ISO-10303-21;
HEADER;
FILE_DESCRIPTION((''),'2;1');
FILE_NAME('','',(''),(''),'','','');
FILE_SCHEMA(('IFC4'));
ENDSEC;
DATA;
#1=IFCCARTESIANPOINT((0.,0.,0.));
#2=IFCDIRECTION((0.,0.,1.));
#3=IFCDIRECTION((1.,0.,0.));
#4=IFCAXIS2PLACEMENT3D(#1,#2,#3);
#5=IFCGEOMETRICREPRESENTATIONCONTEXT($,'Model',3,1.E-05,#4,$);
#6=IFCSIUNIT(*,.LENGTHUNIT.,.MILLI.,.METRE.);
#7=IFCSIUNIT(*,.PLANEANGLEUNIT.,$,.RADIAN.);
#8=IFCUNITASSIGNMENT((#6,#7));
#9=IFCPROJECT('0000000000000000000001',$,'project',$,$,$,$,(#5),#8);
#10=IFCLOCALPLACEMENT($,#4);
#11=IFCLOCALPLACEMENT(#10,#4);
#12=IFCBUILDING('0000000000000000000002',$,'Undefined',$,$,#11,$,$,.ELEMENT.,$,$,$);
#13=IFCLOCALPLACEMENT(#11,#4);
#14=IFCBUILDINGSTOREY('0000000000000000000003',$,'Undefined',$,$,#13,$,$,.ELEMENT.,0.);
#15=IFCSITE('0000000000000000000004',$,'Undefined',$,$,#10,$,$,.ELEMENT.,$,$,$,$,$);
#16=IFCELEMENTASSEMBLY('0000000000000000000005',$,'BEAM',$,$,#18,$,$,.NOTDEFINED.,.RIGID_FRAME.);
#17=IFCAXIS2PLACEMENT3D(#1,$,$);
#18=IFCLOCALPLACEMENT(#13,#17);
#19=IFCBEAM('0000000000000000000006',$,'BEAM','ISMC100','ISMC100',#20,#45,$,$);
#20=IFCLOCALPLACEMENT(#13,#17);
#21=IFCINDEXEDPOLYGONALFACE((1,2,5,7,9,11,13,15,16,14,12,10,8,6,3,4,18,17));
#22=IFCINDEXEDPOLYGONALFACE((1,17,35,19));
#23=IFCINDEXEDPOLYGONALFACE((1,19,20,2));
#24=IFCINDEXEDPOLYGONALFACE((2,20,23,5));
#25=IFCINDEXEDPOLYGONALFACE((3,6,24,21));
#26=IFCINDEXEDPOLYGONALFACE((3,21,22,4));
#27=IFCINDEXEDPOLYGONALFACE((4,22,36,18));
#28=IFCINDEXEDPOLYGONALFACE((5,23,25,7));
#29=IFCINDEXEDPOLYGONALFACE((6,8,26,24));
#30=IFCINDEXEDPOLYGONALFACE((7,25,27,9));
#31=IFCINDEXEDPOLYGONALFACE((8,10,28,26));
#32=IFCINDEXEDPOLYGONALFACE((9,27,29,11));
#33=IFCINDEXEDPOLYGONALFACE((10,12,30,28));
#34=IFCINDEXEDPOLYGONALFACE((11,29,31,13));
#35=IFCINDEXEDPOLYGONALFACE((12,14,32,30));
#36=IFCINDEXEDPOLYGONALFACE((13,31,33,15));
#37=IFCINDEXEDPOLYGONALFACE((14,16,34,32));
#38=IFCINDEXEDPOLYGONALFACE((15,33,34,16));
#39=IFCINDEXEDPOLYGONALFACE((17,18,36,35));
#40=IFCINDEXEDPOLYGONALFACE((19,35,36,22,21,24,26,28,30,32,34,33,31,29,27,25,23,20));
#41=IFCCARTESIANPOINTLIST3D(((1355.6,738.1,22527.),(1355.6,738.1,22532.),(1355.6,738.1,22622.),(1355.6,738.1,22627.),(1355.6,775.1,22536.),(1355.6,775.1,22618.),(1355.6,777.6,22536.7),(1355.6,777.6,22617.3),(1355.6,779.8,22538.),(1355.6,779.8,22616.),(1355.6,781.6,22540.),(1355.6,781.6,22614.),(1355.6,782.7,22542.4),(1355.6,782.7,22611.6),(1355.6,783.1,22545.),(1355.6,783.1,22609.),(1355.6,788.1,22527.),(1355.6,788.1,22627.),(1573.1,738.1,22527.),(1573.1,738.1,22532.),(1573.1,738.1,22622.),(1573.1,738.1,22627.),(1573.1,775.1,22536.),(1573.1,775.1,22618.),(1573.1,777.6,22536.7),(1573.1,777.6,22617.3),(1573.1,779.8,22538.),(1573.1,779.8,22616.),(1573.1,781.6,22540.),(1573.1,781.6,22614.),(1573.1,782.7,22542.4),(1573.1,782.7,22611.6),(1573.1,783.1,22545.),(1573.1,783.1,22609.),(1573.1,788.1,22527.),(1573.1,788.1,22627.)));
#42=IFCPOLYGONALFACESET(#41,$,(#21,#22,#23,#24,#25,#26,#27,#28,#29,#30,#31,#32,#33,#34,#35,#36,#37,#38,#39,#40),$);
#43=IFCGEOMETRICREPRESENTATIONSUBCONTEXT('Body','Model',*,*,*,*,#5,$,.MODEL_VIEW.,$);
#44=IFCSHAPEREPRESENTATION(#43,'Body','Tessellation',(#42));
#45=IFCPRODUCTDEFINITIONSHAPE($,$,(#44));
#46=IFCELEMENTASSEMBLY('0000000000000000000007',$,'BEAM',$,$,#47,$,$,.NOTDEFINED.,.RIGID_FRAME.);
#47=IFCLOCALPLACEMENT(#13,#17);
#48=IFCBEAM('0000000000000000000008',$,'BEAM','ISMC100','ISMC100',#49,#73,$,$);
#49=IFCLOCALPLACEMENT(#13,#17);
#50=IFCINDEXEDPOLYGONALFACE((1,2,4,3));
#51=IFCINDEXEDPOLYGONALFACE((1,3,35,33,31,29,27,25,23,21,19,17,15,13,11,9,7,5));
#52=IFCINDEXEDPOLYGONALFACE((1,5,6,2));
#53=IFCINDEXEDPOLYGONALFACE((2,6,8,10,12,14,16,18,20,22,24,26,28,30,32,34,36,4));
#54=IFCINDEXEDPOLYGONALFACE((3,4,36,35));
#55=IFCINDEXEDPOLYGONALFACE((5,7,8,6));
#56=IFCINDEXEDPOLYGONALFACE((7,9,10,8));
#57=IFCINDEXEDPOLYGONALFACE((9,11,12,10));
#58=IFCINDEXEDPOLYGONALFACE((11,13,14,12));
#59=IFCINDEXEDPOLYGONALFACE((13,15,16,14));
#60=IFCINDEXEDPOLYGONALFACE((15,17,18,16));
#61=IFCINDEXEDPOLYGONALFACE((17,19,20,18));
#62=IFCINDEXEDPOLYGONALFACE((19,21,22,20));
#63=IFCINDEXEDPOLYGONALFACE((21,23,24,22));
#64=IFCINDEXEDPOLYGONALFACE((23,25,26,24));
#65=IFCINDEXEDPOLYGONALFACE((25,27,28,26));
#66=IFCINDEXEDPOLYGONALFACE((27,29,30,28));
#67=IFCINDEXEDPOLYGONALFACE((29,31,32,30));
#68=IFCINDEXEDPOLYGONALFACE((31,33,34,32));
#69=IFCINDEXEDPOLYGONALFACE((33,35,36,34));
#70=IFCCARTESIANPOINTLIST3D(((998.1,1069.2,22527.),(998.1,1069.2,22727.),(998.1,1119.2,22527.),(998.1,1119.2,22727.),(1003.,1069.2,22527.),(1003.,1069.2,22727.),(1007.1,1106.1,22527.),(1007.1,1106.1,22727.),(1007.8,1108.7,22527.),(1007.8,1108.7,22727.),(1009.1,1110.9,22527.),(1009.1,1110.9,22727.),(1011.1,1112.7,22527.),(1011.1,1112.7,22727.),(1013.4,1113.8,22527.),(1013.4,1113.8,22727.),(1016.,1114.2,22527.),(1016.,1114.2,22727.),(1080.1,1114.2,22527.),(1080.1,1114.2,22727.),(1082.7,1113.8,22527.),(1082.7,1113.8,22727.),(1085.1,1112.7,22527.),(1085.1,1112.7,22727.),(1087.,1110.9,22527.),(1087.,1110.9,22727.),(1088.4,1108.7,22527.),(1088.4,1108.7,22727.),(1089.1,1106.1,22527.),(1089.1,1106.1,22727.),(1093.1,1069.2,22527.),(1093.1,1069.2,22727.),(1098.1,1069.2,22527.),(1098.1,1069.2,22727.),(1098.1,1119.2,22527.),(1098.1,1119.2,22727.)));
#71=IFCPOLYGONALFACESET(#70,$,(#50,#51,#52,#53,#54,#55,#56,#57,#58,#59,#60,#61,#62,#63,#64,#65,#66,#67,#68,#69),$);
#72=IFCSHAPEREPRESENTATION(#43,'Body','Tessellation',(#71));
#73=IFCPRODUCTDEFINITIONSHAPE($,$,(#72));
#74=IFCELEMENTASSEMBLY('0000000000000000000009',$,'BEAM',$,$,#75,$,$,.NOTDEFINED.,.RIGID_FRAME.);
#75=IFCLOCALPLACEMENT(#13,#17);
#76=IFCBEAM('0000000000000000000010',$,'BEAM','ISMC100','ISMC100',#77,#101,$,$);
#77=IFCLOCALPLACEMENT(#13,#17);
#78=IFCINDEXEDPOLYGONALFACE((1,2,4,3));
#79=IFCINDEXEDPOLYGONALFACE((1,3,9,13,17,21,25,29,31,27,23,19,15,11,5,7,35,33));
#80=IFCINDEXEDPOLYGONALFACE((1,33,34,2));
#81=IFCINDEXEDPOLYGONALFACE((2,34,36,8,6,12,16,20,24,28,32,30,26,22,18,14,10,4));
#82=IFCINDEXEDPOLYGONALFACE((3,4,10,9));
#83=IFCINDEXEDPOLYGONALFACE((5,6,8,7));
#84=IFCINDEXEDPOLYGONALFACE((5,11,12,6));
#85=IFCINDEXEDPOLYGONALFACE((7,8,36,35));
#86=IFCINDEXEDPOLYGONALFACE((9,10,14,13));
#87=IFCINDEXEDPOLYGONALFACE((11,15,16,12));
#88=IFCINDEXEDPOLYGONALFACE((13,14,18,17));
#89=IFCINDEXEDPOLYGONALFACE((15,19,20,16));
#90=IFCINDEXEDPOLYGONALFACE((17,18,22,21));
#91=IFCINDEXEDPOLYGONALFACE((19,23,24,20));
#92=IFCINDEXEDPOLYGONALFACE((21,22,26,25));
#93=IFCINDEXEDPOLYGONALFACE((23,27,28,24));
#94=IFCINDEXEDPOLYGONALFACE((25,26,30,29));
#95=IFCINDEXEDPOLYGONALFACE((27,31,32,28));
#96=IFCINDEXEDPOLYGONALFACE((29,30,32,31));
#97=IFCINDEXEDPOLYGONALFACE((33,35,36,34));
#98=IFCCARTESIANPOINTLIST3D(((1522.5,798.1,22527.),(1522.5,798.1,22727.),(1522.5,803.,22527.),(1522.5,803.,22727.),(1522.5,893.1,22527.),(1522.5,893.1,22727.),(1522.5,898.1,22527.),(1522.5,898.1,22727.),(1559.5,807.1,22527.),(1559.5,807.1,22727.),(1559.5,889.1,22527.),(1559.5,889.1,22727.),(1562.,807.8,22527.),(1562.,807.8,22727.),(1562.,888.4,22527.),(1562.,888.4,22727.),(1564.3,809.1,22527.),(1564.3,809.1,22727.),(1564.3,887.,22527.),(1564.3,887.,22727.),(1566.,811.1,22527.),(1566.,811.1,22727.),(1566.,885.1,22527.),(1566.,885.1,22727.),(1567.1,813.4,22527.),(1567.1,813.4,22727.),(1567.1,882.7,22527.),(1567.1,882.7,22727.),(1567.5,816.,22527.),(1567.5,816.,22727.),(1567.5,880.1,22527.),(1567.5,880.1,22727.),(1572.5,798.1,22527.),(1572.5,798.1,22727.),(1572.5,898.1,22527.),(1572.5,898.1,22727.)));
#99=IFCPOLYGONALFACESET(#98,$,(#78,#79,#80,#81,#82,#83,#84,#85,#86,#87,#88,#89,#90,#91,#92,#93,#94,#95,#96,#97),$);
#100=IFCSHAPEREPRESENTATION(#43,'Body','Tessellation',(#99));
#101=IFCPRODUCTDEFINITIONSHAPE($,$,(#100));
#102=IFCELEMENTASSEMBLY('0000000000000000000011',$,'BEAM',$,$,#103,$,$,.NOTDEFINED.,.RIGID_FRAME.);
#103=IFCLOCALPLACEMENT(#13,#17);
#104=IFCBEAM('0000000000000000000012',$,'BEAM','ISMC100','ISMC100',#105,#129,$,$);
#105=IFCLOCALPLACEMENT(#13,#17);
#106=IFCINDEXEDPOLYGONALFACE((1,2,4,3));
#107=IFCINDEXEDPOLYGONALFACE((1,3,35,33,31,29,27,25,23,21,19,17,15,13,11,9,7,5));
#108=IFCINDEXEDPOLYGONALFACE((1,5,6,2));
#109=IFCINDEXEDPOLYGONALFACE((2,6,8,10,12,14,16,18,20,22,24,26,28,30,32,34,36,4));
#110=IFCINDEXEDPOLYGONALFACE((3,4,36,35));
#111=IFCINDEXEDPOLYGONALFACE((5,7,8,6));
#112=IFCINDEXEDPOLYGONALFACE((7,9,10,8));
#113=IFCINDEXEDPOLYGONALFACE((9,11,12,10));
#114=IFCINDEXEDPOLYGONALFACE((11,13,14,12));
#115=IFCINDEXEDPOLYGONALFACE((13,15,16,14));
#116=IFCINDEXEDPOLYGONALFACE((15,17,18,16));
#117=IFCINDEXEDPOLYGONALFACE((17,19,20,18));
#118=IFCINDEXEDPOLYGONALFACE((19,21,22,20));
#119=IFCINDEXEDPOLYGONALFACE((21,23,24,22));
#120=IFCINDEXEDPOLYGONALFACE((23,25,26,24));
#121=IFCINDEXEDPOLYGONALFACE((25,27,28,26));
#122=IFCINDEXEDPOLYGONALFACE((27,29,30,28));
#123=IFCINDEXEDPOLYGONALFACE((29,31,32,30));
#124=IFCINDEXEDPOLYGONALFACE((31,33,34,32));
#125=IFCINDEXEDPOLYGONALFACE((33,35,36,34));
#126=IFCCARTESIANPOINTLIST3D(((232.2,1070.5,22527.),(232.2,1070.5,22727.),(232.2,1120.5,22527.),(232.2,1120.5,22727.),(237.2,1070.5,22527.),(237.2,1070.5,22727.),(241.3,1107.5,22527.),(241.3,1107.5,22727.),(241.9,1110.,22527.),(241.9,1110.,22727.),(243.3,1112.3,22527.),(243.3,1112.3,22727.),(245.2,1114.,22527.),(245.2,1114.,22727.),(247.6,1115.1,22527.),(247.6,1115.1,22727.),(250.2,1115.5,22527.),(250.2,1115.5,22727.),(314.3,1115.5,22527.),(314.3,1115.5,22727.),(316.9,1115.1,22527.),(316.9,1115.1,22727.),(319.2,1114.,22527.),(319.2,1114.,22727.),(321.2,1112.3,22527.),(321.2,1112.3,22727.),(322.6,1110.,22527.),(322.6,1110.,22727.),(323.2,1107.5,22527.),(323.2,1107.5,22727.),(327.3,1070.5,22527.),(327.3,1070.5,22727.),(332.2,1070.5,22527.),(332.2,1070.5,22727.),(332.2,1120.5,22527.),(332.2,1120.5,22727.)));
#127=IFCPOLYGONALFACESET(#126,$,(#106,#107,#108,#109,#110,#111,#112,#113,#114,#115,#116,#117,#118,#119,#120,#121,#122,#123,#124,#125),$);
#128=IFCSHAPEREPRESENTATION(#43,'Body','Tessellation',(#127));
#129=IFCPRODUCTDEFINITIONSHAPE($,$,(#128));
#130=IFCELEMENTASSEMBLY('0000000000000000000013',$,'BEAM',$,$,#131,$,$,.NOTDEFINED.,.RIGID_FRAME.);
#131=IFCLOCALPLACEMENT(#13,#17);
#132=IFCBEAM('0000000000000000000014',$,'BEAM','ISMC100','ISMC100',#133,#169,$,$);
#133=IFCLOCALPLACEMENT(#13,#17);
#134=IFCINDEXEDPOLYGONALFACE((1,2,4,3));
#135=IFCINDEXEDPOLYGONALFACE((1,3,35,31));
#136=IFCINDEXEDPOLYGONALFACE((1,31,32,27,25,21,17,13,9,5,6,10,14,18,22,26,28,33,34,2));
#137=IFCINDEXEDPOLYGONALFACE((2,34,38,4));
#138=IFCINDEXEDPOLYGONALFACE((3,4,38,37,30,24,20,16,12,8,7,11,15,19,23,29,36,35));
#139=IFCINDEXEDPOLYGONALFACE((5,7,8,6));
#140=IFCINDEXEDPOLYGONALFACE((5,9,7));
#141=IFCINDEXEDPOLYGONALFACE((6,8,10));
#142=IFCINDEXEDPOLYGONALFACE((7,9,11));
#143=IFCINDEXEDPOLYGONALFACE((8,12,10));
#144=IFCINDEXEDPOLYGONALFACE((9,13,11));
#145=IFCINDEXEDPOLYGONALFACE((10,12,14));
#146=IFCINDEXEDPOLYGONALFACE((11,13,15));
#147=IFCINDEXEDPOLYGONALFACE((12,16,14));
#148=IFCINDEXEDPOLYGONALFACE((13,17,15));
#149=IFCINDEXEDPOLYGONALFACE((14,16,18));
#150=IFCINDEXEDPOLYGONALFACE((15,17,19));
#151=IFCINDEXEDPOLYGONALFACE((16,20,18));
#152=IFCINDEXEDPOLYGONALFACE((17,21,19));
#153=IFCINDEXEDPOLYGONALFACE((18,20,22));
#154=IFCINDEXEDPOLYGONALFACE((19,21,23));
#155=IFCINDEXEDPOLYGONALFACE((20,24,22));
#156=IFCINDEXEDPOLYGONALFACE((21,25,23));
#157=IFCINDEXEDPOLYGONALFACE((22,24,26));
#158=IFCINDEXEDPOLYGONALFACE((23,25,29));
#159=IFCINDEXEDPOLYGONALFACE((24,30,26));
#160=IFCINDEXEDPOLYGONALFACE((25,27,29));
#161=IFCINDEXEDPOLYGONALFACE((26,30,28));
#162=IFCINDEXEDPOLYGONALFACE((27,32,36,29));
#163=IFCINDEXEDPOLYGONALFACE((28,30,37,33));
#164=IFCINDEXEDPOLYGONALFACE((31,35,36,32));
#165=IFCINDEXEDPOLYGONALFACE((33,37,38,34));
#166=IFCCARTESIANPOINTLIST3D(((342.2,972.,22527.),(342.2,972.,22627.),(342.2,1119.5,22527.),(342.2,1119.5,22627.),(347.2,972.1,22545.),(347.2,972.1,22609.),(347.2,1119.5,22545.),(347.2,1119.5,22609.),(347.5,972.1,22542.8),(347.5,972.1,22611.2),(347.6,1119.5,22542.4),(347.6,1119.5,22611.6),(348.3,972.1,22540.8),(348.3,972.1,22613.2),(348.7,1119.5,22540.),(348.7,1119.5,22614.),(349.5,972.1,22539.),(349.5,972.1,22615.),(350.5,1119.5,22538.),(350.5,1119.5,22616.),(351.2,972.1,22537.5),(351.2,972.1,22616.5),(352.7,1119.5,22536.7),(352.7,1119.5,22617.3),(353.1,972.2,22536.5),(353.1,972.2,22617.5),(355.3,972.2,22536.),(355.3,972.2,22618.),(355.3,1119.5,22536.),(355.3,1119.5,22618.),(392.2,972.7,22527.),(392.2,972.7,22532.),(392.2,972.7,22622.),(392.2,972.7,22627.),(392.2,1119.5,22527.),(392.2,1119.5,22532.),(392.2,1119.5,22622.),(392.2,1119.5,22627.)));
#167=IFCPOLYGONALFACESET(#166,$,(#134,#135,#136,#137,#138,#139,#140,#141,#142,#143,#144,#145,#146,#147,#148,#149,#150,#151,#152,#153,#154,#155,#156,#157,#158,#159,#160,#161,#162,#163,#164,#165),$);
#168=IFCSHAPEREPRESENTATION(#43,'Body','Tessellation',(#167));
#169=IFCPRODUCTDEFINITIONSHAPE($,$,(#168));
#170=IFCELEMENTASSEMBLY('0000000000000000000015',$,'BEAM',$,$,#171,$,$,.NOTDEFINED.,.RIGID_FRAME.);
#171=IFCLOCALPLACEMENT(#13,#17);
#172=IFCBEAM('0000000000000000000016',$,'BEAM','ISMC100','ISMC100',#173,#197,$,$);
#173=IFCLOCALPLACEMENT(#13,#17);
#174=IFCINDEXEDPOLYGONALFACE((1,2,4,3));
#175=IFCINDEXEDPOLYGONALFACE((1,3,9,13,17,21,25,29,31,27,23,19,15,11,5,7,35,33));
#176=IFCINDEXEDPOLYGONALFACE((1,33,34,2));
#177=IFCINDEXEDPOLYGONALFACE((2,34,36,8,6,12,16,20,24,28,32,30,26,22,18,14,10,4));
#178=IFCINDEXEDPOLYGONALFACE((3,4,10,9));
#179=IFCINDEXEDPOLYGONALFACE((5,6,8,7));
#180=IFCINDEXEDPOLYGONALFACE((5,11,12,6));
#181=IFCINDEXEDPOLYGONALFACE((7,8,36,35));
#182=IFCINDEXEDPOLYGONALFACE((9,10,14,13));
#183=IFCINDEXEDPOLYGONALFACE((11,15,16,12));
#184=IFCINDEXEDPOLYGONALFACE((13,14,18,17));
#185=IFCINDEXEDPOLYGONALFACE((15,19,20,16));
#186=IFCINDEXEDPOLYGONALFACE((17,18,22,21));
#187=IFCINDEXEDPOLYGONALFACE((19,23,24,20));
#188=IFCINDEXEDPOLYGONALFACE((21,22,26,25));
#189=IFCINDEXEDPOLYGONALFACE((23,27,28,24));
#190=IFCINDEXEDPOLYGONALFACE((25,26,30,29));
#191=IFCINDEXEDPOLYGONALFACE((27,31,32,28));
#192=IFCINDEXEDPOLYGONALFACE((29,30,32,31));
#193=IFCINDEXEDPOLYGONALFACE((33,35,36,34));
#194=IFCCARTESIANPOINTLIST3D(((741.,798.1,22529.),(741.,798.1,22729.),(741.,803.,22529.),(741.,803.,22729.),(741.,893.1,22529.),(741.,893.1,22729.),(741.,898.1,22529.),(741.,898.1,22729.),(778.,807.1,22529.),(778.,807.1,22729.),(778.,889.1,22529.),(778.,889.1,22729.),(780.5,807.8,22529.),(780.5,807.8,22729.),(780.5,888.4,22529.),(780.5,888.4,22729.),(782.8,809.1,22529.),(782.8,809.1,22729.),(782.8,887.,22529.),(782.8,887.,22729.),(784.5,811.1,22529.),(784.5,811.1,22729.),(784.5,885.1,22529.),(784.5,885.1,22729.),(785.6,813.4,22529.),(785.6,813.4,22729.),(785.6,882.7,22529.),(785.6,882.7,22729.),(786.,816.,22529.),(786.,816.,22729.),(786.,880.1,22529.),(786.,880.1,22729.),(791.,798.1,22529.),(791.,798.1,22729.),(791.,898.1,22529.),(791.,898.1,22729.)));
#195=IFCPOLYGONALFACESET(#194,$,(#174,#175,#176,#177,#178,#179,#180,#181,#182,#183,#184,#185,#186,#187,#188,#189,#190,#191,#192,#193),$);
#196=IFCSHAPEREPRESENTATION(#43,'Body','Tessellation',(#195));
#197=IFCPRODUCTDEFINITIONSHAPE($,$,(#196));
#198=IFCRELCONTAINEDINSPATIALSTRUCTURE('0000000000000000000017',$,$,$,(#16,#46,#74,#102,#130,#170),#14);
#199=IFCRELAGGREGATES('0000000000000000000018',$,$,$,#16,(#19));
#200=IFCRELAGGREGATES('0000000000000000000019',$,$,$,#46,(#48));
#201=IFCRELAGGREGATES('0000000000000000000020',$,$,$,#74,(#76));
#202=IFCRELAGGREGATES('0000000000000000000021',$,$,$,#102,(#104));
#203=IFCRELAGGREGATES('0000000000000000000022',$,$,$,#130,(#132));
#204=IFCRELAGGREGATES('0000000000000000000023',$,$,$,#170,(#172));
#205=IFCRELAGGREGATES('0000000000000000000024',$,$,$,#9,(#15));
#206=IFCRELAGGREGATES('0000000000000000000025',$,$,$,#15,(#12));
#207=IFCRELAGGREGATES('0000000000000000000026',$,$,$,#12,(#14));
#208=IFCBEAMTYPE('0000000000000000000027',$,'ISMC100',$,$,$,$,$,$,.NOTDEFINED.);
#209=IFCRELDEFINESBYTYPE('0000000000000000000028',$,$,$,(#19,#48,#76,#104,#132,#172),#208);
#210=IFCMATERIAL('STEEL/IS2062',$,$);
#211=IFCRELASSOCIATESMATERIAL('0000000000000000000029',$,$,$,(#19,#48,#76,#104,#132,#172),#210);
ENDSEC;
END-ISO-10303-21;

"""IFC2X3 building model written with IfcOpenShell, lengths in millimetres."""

from ifc_helpers import new_model, si_unit, frame, origin_with_axes, origin_2d_with_axis, place, context, subcontext, project, spatial, u_section, extrude, clip, halfspace, material, type_object, element, aggregate, save


model = new_model("IFC2X3")

# Units and contexts
model_context = context("Model", 3, precision=1e-05, world=origin_with_axes())
body_context = subcontext(model_context, "Body", "Model", "MODEL_VIEW")
ifc_project = project(units=[si_unit("LENGTHUNIT", "METRE", prefix="MILLI"), si_unit("PLANEANGLEUNIT", "RADIAN")], contexts=[model_context])

# Site, building, storey
site_placement = place(None, origin_with_axes())
site = spatial("IfcSite", under=ifc_project, at=site_placement, Name="Undefined", CompositionType="ELEMENT")
building_placement = place(site_placement, origin_with_axes())
building = spatial("IfcBuilding", under=site, at=building_placement, Name="Undefined", CompositionType="ELEMENT")
storey_placement = place(building_placement, origin_with_axes())
storey = spatial("IfcBuildingStorey", under=building, at=storey_placement, Name="Undefined", CompositionType="ELEMENT", Elevation=0.0)

# Shared definitions
ifc_material = material(Name="STEEL/IS2062")

# Element assemblies, beams
beam_type_1 = type_object("IfcBeamType", Name="ISMC100", PredefinedType="NOTDEFINED")
assembly_1_placement = place(storey_placement, origin_with_axes())
assembly_1 = element("IfcElementAssembly", 1, at=assembly_1_placement, inside=storey, Name="BEAM", AssemblyPlace="NOTDEFINED", PredefinedType="RIGID_FRAME")
beam_1_placement = place(assembly_1_placement, frame((1573.1, 763.1, 22577.0), z_axis=(0.0, 0.0, -1.0), x_axis=(-1.0, 0.0, 0.0)))
beam_1 = element("IfcBeam", 2, at=beam_1_placement, type_object=beam_type_1, material=ifc_material, Name="BEAM", Description="ISMC100", ObjectType="ISMC100", context=body_context, shape_type="SweptSolid", body=[
    extrude(u_section(Depth=100.0, FlangeWidth=50.0, WebThickness=5.0, FlangeThickness=7.7, FilletRadius=9.0, FlangeSlope=0.10956, at=origin_2d_with_axis()), frame((217.6, 0.0, 0.0), z_axis=(-1.0, 0.0, 0.0), x_axis=(0.0, -1.0, 0.0)), (0.0, 0.0, 1.0), 217.6),
])
aggregate(assembly_1, [beam_1])
assembly_2_placement = place(storey_placement, origin_with_axes())
assembly_2 = element("IfcElementAssembly", 3, at=assembly_2_placement, inside=storey, Name="BEAM", AssemblyPlace="NOTDEFINED", PredefinedType="RIGID_FRAME")
beam_2_placement = place(assembly_2_placement, frame((1048.1, 1094.2, 22727.0), z_axis=(1.0, 0.0, 0.0), x_axis=(0.0, 0.0, -1.0)))
beam_2 = element("IfcBeam", 4, at=beam_2_placement, type_object=beam_type_1, material=ifc_material, Name="BEAM", Description="ISMC100", ObjectType="ISMC100", context=body_context, shape_type="SweptSolid", body=[
    extrude(u_section(Depth=100.0, FlangeWidth=50.0, WebThickness=5.0, FlangeThickness=7.7, FilletRadius=9.0, FlangeSlope=0.10956, at=origin_2d_with_axis()), frame((200.0, 0.0, 0.0), z_axis=(-1.0, 0.0, 0.0), x_axis=(0.0, -1.0, 0.0)), (0.0, 0.0, 1.0), 200.0),
])
aggregate(assembly_2, [beam_2])
assembly_3_placement = place(storey_placement, origin_with_axes())
assembly_3 = element("IfcElementAssembly", 5, at=assembly_3_placement, inside=storey, Name="BEAM", AssemblyPlace="NOTDEFINED", PredefinedType="RIGID_FRAME")
beam_3_placement = place(assembly_3_placement, frame((1547.5, 848.1, 22727.0), z_axis=(0.0, -1.0, 0.0), x_axis=(0.0, 0.0, -1.0)))
beam_3 = element("IfcBeam", 6, at=beam_3_placement, type_object=beam_type_1, material=ifc_material, Name="BEAM", Description="ISMC100", ObjectType="ISMC100", context=body_context, shape_type="SweptSolid", body=[
    extrude(u_section(Depth=100.0, FlangeWidth=50.0, WebThickness=5.0, FlangeThickness=7.7, FilletRadius=9.0, FlangeSlope=0.10956, at=origin_2d_with_axis()), frame((200.0, 0.0, 0.0), z_axis=(-1.0, 0.0, 0.0), x_axis=(0.0, -1.0, 0.0)), (0.0, 0.0, 1.0), 200.0),
])
aggregate(assembly_3, [beam_3])
assembly_4_placement = place(storey_placement, origin_with_axes())
assembly_4 = element("IfcElementAssembly", 7, at=assembly_4_placement, inside=storey, Name="BEAM", AssemblyPlace="NOTDEFINED", PredefinedType="RIGID_FRAME")
beam_4_placement = place(assembly_4_placement, frame((282.2, 1095.5, 22727.0), z_axis=(1.0, 0.0, 0.0), x_axis=(0.0, 0.0, -1.0)))
beam_4 = element("IfcBeam", 8, at=beam_4_placement, type_object=beam_type_1, material=ifc_material, Name="BEAM", Description="ISMC100", ObjectType="ISMC100", context=body_context, shape_type="SweptSolid", body=[
    extrude(u_section(Depth=100.0, FlangeWidth=50.0, WebThickness=5.0, FlangeThickness=7.7, FilletRadius=9.0, FlangeSlope=0.10956, at=origin_2d_with_axis()), frame((200.0, 0.0, 0.0), z_axis=(-1.0, 0.0, 0.0), x_axis=(0.0, -1.0, 0.0)), (0.0, 0.0, 1.0), 200.0),
])
aggregate(assembly_4, [beam_4])
assembly_5_placement = place(storey_placement, origin_with_axes())
assembly_5 = element("IfcElementAssembly", 9, at=assembly_5_placement, inside=storey, Name="BEAM", AssemblyPlace="NOTDEFINED", PredefinedType="RIGID_FRAME")
beam_5_placement = place(assembly_5_placement, frame((367.2, 1119.5, 22577.0), z_axis=(0.0, 0.0, -1.0), x_axis=(0.0, -1.0, 0.0)))
beam_5 = element("IfcBeam", 10, at=beam_5_placement, type_object=beam_type_1, material=ifc_material, Name="BEAM", Description="ISMC100", ObjectType="ISMC100", context=body_context, shape_type="Clipping", body=[
    clip(extrude(u_section(Depth=100.0, FlangeWidth=50.0, WebThickness=5.0, FlangeThickness=7.7, FilletRadius=9.0, FlangeSlope=0.10956, at=origin_2d_with_axis()), frame((147.5, 0.0, 0.0), z_axis=(-1.0, 0.0, 0.0), x_axis=(0.0, -1.0, 0.0)), (0.0, 0.0, 1.0), 147.5), halfspace(frame((147.5, 25.0, -50.0), z_axis=(0.999902, -0.013997, 0.0), x_axis=(-0.013997, -0.999902, 0.0)), False)),
])
aggregate(assembly_5, [beam_5])
assembly_6_placement = place(storey_placement, origin_with_axes())
assembly_6 = element("IfcElementAssembly", 11, at=assembly_6_placement, inside=storey, Name="BEAM", AssemblyPlace="NOTDEFINED", PredefinedType="RIGID_FRAME")
beam_6_placement = place(assembly_6_placement, frame((766.0, 848.1, 22729.0), z_axis=(0.0, -1.0, 0.0), x_axis=(0.0, 0.0, -1.0)))
beam_6 = element("IfcBeam", 12, at=beam_6_placement, type_object=beam_type_1, material=ifc_material, Name="BEAM", Description="ISMC100", ObjectType="ISMC100", context=body_context, shape_type="SweptSolid", body=[
    extrude(u_section(Depth=100.0, FlangeWidth=50.0, WebThickness=5.0, FlangeThickness=7.7, FilletRadius=9.0, FlangeSlope=0.10956, at=origin_2d_with_axis()), frame((200.0, 0.0, 0.0), z_axis=(-1.0, 0.0, 0.0), x_axis=(0.0, -1.0, 0.0)), (0.0, 0.0, 1.0), 200.0),
])
aggregate(assembly_6, [beam_6])

save(model, "model.ifc")
